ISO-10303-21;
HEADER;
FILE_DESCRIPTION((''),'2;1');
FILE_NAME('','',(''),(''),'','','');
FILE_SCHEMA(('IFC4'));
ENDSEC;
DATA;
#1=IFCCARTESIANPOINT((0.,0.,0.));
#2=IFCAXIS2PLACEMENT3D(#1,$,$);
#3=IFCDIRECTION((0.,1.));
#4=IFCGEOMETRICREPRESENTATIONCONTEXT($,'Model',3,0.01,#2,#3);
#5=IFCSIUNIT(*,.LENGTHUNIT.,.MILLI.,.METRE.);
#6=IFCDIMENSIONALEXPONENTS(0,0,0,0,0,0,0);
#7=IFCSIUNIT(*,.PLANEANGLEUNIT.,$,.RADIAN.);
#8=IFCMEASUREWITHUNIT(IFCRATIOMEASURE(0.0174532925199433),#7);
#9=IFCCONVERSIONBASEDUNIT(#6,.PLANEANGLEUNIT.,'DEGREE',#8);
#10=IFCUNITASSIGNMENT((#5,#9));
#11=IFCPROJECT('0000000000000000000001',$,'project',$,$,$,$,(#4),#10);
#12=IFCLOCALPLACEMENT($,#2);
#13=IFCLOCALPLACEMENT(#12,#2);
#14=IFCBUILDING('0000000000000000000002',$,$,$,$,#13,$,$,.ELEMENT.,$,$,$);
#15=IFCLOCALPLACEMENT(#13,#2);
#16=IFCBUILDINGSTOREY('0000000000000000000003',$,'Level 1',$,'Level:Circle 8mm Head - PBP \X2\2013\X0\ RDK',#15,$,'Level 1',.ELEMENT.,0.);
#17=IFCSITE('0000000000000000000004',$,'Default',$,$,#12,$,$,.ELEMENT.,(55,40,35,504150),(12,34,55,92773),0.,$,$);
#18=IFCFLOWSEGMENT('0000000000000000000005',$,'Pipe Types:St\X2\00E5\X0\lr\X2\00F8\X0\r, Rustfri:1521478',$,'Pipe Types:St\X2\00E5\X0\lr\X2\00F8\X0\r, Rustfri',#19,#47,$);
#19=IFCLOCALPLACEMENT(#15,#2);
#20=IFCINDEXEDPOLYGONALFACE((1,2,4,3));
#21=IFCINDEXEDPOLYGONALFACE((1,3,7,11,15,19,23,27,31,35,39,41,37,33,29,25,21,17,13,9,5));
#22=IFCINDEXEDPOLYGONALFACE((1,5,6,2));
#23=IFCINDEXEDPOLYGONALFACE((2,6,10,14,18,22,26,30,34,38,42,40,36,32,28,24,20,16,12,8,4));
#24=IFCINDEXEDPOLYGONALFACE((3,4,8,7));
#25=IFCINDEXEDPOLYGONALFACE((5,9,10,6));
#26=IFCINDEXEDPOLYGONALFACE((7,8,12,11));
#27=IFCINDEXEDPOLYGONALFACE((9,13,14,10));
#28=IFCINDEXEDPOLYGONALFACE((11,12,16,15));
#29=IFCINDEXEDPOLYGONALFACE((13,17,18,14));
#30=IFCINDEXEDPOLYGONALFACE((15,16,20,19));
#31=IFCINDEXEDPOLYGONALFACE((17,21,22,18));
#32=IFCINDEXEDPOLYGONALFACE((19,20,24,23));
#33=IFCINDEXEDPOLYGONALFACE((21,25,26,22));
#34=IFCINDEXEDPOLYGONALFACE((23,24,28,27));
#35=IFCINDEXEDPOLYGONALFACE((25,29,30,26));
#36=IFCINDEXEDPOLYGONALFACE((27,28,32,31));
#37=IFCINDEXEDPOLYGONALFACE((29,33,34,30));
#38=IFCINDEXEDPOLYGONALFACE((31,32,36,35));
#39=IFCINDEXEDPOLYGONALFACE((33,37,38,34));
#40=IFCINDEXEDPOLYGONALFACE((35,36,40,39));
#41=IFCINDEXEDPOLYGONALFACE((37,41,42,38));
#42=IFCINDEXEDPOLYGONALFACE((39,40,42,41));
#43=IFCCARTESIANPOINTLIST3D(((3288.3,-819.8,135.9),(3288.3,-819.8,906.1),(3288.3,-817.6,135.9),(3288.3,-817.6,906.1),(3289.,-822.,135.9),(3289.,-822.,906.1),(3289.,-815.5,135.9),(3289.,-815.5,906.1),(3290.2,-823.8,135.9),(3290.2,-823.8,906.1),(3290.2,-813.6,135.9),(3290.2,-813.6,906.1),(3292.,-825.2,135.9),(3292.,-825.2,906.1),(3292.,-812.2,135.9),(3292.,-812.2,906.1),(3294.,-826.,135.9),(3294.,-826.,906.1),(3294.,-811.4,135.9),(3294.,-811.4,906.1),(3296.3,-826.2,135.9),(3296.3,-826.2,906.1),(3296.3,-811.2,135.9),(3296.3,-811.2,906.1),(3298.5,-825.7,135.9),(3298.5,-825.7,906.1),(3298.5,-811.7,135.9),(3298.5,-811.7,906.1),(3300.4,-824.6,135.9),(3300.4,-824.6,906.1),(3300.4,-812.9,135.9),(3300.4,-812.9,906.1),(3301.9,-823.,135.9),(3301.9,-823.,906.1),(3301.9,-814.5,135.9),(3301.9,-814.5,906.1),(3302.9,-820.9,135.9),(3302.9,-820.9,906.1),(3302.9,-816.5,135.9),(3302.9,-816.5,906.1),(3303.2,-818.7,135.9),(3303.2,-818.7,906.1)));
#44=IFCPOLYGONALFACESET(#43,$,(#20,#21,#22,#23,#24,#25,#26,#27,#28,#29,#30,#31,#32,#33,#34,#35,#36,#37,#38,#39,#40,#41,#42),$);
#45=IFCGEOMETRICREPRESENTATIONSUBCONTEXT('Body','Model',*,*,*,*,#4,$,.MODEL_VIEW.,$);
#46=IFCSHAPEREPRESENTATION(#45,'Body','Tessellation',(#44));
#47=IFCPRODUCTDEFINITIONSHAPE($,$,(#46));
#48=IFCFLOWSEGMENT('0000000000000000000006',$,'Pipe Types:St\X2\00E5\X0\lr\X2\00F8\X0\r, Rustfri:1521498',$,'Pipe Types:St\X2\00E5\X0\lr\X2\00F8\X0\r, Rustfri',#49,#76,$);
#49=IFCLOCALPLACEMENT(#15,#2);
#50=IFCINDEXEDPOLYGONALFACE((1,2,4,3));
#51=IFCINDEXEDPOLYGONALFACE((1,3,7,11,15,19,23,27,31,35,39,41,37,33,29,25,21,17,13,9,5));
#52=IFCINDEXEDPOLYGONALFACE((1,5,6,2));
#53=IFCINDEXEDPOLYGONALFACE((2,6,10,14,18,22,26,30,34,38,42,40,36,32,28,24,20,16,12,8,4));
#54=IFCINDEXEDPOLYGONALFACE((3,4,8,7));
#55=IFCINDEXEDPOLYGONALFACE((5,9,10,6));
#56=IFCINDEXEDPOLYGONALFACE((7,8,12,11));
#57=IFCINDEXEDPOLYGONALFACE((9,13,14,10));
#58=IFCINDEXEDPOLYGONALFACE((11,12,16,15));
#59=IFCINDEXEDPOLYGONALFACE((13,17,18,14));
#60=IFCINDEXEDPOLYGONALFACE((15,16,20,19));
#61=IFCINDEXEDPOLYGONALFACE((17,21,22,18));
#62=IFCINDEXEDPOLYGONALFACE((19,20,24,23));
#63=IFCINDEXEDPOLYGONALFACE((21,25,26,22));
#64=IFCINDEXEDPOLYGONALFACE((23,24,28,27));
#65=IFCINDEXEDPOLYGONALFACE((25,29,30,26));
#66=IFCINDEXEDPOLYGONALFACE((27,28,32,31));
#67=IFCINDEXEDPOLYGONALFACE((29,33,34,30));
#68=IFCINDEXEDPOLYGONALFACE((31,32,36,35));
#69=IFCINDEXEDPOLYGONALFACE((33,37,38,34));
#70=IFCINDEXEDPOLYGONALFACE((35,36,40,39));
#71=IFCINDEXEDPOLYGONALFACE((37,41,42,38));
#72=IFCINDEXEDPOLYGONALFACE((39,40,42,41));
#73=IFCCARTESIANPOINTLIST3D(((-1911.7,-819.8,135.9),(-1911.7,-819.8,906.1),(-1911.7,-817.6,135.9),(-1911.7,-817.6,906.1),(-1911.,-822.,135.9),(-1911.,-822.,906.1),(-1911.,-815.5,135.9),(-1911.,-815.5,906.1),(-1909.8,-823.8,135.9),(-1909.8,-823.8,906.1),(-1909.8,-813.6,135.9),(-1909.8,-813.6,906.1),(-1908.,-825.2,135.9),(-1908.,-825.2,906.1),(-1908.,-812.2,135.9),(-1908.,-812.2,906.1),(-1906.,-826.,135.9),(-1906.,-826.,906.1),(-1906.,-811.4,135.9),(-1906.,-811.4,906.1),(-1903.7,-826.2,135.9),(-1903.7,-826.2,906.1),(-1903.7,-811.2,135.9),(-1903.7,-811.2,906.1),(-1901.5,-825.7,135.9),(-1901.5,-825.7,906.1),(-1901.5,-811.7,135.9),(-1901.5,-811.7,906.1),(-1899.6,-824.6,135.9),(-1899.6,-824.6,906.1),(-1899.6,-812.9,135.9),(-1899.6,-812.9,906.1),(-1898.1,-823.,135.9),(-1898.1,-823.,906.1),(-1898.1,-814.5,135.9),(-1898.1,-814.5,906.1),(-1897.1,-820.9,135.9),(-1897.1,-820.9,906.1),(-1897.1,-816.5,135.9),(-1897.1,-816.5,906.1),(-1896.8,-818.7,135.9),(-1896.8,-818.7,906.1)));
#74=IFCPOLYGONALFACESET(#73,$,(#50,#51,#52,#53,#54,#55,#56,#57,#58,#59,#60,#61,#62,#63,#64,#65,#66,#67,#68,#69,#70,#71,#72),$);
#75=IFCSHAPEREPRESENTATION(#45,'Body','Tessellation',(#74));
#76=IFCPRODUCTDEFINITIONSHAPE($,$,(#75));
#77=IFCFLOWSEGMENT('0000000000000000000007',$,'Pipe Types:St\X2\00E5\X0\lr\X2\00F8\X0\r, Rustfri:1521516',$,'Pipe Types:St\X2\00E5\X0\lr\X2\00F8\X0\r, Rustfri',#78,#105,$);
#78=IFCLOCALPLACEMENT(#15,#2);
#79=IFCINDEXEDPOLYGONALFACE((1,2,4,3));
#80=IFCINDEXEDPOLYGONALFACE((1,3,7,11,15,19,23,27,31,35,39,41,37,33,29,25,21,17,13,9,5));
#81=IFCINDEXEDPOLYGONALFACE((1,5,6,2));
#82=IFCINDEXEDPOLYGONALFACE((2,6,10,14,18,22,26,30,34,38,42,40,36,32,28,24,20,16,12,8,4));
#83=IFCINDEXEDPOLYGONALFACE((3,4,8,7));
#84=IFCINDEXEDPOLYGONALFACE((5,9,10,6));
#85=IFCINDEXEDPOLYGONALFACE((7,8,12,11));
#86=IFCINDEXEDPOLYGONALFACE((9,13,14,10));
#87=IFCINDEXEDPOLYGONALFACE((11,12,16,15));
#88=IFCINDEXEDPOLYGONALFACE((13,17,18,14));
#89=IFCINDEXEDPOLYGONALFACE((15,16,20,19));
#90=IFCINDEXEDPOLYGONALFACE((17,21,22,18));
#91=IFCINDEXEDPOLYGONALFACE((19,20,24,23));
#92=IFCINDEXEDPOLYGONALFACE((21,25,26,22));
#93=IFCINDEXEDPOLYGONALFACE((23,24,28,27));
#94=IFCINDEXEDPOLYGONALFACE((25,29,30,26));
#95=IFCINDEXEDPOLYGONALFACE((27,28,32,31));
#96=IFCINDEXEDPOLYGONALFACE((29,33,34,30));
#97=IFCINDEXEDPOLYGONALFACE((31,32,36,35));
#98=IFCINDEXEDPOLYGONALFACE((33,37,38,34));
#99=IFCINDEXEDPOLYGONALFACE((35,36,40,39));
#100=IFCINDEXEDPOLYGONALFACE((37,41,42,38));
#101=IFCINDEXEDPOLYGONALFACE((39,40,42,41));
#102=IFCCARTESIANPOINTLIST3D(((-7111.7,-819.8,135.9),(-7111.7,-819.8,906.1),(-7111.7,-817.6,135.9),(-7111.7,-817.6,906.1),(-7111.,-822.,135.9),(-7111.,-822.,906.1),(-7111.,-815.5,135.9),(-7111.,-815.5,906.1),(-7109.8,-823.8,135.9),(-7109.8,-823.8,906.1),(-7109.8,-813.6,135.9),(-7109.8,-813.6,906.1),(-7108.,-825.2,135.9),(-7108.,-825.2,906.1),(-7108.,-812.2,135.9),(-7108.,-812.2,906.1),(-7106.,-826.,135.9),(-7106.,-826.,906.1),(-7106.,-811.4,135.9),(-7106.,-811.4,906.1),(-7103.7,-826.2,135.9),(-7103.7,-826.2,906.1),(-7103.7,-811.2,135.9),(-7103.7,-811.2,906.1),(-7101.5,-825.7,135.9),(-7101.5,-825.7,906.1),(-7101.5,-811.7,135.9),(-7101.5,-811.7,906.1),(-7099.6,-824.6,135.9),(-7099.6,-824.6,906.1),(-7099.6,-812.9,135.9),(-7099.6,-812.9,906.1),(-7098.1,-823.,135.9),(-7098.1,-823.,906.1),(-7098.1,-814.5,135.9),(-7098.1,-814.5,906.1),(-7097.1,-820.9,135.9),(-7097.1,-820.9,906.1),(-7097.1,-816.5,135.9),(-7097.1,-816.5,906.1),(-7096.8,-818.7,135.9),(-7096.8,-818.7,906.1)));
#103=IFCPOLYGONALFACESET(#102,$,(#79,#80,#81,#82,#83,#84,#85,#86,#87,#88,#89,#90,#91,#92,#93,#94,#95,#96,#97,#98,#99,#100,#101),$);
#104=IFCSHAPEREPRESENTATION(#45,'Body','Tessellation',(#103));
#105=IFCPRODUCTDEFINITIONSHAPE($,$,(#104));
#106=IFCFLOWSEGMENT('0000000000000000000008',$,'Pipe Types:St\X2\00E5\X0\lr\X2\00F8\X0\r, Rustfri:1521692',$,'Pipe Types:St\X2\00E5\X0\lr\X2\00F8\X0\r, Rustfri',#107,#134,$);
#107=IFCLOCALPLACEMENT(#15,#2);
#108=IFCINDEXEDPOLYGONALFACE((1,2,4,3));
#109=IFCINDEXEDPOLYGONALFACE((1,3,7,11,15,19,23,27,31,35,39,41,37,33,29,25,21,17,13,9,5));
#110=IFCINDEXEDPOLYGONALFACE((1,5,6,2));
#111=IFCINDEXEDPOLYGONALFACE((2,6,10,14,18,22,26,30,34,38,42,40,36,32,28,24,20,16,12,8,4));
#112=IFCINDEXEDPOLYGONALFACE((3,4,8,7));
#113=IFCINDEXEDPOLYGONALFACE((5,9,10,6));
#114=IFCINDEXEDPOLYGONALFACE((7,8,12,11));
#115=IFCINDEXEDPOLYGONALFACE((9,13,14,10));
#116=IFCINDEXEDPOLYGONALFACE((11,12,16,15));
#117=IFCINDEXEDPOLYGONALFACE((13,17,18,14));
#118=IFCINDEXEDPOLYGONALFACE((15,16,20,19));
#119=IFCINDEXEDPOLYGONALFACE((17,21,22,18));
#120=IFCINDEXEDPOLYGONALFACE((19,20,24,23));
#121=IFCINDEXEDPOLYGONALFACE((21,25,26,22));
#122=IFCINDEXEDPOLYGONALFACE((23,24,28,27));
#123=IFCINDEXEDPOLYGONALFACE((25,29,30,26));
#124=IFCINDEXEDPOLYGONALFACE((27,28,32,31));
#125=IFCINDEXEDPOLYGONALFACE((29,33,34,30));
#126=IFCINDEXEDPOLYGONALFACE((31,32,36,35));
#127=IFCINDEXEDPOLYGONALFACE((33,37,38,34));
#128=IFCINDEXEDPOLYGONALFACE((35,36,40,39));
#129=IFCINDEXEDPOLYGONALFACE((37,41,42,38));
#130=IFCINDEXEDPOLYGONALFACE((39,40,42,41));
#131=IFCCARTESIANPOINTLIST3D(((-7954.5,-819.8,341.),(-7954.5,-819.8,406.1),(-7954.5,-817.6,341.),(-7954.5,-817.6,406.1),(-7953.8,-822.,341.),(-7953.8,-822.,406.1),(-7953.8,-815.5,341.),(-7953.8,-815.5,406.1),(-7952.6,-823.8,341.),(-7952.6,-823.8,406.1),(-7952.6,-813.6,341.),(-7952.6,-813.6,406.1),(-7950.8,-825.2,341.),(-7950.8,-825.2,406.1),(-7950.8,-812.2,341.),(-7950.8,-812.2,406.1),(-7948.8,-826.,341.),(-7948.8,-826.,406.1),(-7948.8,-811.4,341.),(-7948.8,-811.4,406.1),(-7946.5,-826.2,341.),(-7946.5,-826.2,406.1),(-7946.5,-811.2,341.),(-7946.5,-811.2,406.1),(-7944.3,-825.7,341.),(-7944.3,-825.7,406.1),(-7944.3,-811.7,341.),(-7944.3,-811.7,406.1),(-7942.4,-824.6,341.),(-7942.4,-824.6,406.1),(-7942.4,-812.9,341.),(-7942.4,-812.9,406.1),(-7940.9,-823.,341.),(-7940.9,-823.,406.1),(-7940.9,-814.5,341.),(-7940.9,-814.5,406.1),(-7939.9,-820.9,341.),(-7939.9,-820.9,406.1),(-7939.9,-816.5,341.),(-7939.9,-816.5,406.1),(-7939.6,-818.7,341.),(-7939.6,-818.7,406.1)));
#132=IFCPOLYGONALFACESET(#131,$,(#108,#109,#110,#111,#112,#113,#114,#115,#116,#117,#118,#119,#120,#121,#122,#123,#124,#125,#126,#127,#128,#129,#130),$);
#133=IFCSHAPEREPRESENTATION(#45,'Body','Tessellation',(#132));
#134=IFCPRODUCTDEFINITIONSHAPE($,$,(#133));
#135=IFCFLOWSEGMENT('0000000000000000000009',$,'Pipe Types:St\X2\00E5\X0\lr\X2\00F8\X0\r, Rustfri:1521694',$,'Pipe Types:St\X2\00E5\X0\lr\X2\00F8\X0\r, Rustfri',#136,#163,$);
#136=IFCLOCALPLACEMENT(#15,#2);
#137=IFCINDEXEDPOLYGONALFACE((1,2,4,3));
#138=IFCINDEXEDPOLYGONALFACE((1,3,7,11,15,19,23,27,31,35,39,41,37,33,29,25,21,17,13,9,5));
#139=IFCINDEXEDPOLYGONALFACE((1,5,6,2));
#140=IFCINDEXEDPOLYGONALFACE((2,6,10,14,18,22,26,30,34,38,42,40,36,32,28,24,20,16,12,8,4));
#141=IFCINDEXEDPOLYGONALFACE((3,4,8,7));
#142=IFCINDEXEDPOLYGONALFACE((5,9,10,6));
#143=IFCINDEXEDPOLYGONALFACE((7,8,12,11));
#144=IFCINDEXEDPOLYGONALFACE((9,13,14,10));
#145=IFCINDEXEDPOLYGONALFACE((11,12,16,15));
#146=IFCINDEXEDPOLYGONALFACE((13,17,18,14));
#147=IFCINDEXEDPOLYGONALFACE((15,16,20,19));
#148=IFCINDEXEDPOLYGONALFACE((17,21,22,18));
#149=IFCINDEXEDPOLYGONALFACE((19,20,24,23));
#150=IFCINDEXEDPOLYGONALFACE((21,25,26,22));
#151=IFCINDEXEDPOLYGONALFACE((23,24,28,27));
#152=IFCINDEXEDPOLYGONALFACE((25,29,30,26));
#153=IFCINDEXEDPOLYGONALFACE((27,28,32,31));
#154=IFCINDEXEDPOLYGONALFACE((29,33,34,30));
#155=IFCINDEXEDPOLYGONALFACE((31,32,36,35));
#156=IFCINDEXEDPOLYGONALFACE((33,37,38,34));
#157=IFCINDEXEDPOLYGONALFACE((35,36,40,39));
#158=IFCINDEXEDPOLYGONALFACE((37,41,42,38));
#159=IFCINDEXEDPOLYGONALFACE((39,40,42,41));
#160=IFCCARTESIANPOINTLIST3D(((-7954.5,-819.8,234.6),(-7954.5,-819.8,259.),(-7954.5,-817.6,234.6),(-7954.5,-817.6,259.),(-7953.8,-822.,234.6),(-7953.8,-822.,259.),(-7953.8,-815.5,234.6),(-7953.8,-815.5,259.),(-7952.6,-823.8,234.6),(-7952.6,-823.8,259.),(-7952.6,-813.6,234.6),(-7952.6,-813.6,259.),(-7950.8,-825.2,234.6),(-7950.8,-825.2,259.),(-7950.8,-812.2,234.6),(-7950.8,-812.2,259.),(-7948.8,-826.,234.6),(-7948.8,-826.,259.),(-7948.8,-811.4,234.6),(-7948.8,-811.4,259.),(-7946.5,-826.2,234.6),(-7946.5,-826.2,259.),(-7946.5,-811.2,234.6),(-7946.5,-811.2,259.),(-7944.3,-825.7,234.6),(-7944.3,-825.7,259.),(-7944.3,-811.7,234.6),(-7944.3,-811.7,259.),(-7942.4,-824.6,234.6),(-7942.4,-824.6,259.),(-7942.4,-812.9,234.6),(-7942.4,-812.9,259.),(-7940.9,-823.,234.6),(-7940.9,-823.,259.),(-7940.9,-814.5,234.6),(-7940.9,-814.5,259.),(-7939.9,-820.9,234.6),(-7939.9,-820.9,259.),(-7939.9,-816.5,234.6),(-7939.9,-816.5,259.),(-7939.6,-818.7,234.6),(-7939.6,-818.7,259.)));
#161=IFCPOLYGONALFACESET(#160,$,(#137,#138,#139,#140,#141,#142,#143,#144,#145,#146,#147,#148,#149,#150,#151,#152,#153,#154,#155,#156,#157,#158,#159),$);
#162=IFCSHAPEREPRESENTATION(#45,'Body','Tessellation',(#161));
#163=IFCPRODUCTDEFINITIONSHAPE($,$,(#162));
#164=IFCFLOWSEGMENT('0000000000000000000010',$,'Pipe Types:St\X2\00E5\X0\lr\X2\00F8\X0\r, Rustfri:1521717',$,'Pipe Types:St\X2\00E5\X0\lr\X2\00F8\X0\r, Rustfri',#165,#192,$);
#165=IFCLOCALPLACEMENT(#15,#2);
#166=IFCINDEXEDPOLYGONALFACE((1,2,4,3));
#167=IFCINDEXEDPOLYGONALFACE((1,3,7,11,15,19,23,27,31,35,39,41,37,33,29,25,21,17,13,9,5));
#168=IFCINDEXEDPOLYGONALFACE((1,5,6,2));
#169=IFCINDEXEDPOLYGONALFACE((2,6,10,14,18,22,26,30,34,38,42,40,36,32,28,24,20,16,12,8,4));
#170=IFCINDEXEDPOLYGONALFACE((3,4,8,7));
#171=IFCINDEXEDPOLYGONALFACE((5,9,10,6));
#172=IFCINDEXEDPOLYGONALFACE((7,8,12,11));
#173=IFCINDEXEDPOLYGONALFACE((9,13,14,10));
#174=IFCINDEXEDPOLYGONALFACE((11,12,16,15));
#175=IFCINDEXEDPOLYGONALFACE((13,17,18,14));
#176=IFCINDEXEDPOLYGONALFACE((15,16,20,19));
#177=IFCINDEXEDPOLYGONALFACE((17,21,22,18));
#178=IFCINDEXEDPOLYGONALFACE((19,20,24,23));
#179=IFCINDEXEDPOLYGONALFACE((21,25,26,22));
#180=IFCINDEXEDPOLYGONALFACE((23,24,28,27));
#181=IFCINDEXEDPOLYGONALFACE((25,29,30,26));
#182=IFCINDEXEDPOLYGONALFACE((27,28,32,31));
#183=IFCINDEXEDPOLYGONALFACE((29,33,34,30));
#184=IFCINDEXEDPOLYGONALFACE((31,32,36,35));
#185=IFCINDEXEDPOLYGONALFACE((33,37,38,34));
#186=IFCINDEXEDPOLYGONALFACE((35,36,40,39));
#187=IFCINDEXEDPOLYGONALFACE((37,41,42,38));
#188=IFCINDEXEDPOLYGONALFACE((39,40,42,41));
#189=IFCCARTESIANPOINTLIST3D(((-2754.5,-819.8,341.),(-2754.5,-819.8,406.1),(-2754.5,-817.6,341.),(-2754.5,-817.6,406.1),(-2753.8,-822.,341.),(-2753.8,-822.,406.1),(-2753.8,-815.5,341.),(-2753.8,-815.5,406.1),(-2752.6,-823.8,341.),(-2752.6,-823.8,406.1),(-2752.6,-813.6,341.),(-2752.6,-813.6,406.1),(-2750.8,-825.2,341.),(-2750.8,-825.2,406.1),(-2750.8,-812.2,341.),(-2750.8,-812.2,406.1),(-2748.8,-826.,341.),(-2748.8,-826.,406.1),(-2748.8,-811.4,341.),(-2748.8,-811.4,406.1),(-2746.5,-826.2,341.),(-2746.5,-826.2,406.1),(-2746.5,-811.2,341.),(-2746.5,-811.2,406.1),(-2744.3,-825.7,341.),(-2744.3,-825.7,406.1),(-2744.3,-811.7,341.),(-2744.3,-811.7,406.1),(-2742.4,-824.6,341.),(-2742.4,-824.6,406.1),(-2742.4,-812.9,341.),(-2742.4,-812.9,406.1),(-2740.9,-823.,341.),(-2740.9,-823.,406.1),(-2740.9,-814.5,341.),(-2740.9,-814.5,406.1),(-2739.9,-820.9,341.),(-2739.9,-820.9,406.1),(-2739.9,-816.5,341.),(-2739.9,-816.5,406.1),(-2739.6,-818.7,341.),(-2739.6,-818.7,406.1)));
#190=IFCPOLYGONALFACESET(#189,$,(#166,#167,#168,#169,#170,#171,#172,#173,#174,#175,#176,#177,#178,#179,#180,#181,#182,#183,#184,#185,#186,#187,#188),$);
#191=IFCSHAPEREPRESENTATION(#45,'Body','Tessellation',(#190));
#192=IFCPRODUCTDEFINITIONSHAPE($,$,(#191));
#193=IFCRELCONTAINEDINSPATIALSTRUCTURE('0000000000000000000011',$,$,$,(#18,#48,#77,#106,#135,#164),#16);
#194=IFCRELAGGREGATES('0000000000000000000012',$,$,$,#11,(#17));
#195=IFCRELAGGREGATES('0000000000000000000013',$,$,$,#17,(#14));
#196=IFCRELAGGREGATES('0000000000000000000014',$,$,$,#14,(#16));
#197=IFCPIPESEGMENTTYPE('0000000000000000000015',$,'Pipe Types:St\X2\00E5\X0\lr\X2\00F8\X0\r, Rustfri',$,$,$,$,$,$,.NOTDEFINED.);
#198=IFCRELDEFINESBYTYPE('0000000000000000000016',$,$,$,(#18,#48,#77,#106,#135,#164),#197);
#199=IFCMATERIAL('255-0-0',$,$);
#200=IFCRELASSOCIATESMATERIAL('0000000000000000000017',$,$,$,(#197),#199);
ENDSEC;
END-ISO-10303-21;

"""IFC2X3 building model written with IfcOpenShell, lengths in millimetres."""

from ifc_helpers import new_model, entity, si_unit, converted_unit, direction, frame, frame_2d, origin, place, context, subcontext, project, spatial, circle, extrude, material, type_object, element, save


model = new_model("IFC2X3")

# Units and contexts
model_context = context("Model", 3, precision=0.01, world=origin(), true_north=direction((0.0, 1.0)))
body_context = subcontext(model_context, "Body", "Model", "MODEL_VIEW")
ifc_project = project(units=[si_unit("LENGTHUNIT", "METRE", prefix="MILLI"), converted_unit("PLANEANGLEUNIT", "DEGREE", entity("IfcRatioMeasure", 0.0174532925199433), si_unit("PLANEANGLEUNIT", "RADIAN"), dimensions=[0, 0, 0, 0, 0, 0, 0])], contexts=[model_context])

# Site, building, storey
site_placement = place(None, origin())
site = spatial("IfcSite", under=ifc_project, at=site_placement, Name="Default", CompositionType="ELEMENT", RefLatitude=(55, 40, 35, 504150), RefLongitude=(12, 34, 55, 92773), RefElevation=0.0)
building_placement = place(site_placement, origin())
building = spatial("IfcBuilding", under=site, at=building_placement, CompositionType="ELEMENT")
storey_placement = place(building_placement, origin())
storey = spatial("IfcBuildingStorey", under=building, at=storey_placement, Name="Level 1", ObjectType="Level:Circle 8mm Head - PBP – RDK", LongName="Level 1", CompositionType="ELEMENT", Elevation=0.0)

# Flow segments
ifc_material = material(Name="255-0-0")
pipe_segment_type = type_object("IfcPipeSegmentType", Name="Pipe Types:Stålrør, Rustfri", PredefinedType="NOTDEFINED", material=ifc_material)
flow_segment_1_placement = place(storey_placement, origin())
element("IfcFlowSegment", 1, at=flow_segment_1_placement, inside=storey, type_object=pipe_segment_type, Name="Pipe Types:Stålrør, Rustfri:1521478", ObjectType="Pipe Types:Stålrør, Rustfri", context=body_context, shape_type="SweptSolid", body=[
    extrude(circle(Radius=7.5, at=frame_2d((0.0, 0.0), x_axis=(1.0, 0.0))), frame((3295.7, -818.7, 135.9)), (0.0, 0.0, 1.0), 770.2),
])
flow_segment_2_placement = place(storey_placement, origin())
element("IfcFlowSegment", 2, at=flow_segment_2_placement, inside=storey, type_object=pipe_segment_type, Name="Pipe Types:Stålrør, Rustfri:1521498", ObjectType="Pipe Types:Stålrør, Rustfri", context=body_context, shape_type="SweptSolid", body=[
    extrude(circle(Radius=7.5, at=frame_2d((0.0, 0.0), x_axis=(1.0, 0.0))), frame((-1904.3, -818.7, 135.9)), (0.0, 0.0, 1.0), 770.2),
])
flow_segment_3_placement = place(storey_placement, origin())
element("IfcFlowSegment", 3, at=flow_segment_3_placement, inside=storey, type_object=pipe_segment_type, Name="Pipe Types:Stålrør, Rustfri:1521516", ObjectType="Pipe Types:Stålrør, Rustfri", context=body_context, shape_type="SweptSolid", body=[
    extrude(circle(Radius=7.5, at=frame_2d((0.0, 0.0), x_axis=(1.0, 0.0))), frame((-7104.3, -818.7, 135.9)), (0.0, 0.0, 1.0), 770.2),
])
flow_segment_4_placement = place(storey_placement, origin())
element("IfcFlowSegment", 4, at=flow_segment_4_placement, inside=storey, type_object=pipe_segment_type, Name="Pipe Types:Stålrør, Rustfri:1521692", ObjectType="Pipe Types:Stålrør, Rustfri", context=body_context, shape_type="SweptSolid", body=[
    extrude(circle(Radius=7.5, at=frame_2d((0.0, 0.0), x_axis=(1.0, 0.0))), frame((-7947.1, -818.7, 341.0)), (0.0, 0.0, 1.0), 65.1),
])
flow_segment_5_placement = place(storey_placement, origin())
element("IfcFlowSegment", 5, at=flow_segment_5_placement, inside=storey, type_object=pipe_segment_type, Name="Pipe Types:Stålrør, Rustfri:1521694", ObjectType="Pipe Types:Stålrør, Rustfri", context=body_context, shape_type="SweptSolid", body=[
    extrude(circle(Radius=7.5, at=frame_2d((0.0, 0.0), x_axis=(1.0, 0.0))), frame((-7947.1, -818.7, 234.6)), (0.0, 0.0, 1.0), 24.4),
])
flow_segment_6_placement = place(storey_placement, origin())
element("IfcFlowSegment", 6, at=flow_segment_6_placement, inside=storey, type_object=pipe_segment_type, Name="Pipe Types:Stålrør, Rustfri:1521717", ObjectType="Pipe Types:Stålrør, Rustfri", context=body_context, shape_type="SweptSolid", body=[
    extrude(circle(Radius=7.5, at=frame_2d((0.0, 0.0), x_axis=(1.0, 0.0))), frame((-2747.1, -818.7, 341.0)), (0.0, 0.0, 1.0), 65.1),
])

save(model, "model.ifc")
